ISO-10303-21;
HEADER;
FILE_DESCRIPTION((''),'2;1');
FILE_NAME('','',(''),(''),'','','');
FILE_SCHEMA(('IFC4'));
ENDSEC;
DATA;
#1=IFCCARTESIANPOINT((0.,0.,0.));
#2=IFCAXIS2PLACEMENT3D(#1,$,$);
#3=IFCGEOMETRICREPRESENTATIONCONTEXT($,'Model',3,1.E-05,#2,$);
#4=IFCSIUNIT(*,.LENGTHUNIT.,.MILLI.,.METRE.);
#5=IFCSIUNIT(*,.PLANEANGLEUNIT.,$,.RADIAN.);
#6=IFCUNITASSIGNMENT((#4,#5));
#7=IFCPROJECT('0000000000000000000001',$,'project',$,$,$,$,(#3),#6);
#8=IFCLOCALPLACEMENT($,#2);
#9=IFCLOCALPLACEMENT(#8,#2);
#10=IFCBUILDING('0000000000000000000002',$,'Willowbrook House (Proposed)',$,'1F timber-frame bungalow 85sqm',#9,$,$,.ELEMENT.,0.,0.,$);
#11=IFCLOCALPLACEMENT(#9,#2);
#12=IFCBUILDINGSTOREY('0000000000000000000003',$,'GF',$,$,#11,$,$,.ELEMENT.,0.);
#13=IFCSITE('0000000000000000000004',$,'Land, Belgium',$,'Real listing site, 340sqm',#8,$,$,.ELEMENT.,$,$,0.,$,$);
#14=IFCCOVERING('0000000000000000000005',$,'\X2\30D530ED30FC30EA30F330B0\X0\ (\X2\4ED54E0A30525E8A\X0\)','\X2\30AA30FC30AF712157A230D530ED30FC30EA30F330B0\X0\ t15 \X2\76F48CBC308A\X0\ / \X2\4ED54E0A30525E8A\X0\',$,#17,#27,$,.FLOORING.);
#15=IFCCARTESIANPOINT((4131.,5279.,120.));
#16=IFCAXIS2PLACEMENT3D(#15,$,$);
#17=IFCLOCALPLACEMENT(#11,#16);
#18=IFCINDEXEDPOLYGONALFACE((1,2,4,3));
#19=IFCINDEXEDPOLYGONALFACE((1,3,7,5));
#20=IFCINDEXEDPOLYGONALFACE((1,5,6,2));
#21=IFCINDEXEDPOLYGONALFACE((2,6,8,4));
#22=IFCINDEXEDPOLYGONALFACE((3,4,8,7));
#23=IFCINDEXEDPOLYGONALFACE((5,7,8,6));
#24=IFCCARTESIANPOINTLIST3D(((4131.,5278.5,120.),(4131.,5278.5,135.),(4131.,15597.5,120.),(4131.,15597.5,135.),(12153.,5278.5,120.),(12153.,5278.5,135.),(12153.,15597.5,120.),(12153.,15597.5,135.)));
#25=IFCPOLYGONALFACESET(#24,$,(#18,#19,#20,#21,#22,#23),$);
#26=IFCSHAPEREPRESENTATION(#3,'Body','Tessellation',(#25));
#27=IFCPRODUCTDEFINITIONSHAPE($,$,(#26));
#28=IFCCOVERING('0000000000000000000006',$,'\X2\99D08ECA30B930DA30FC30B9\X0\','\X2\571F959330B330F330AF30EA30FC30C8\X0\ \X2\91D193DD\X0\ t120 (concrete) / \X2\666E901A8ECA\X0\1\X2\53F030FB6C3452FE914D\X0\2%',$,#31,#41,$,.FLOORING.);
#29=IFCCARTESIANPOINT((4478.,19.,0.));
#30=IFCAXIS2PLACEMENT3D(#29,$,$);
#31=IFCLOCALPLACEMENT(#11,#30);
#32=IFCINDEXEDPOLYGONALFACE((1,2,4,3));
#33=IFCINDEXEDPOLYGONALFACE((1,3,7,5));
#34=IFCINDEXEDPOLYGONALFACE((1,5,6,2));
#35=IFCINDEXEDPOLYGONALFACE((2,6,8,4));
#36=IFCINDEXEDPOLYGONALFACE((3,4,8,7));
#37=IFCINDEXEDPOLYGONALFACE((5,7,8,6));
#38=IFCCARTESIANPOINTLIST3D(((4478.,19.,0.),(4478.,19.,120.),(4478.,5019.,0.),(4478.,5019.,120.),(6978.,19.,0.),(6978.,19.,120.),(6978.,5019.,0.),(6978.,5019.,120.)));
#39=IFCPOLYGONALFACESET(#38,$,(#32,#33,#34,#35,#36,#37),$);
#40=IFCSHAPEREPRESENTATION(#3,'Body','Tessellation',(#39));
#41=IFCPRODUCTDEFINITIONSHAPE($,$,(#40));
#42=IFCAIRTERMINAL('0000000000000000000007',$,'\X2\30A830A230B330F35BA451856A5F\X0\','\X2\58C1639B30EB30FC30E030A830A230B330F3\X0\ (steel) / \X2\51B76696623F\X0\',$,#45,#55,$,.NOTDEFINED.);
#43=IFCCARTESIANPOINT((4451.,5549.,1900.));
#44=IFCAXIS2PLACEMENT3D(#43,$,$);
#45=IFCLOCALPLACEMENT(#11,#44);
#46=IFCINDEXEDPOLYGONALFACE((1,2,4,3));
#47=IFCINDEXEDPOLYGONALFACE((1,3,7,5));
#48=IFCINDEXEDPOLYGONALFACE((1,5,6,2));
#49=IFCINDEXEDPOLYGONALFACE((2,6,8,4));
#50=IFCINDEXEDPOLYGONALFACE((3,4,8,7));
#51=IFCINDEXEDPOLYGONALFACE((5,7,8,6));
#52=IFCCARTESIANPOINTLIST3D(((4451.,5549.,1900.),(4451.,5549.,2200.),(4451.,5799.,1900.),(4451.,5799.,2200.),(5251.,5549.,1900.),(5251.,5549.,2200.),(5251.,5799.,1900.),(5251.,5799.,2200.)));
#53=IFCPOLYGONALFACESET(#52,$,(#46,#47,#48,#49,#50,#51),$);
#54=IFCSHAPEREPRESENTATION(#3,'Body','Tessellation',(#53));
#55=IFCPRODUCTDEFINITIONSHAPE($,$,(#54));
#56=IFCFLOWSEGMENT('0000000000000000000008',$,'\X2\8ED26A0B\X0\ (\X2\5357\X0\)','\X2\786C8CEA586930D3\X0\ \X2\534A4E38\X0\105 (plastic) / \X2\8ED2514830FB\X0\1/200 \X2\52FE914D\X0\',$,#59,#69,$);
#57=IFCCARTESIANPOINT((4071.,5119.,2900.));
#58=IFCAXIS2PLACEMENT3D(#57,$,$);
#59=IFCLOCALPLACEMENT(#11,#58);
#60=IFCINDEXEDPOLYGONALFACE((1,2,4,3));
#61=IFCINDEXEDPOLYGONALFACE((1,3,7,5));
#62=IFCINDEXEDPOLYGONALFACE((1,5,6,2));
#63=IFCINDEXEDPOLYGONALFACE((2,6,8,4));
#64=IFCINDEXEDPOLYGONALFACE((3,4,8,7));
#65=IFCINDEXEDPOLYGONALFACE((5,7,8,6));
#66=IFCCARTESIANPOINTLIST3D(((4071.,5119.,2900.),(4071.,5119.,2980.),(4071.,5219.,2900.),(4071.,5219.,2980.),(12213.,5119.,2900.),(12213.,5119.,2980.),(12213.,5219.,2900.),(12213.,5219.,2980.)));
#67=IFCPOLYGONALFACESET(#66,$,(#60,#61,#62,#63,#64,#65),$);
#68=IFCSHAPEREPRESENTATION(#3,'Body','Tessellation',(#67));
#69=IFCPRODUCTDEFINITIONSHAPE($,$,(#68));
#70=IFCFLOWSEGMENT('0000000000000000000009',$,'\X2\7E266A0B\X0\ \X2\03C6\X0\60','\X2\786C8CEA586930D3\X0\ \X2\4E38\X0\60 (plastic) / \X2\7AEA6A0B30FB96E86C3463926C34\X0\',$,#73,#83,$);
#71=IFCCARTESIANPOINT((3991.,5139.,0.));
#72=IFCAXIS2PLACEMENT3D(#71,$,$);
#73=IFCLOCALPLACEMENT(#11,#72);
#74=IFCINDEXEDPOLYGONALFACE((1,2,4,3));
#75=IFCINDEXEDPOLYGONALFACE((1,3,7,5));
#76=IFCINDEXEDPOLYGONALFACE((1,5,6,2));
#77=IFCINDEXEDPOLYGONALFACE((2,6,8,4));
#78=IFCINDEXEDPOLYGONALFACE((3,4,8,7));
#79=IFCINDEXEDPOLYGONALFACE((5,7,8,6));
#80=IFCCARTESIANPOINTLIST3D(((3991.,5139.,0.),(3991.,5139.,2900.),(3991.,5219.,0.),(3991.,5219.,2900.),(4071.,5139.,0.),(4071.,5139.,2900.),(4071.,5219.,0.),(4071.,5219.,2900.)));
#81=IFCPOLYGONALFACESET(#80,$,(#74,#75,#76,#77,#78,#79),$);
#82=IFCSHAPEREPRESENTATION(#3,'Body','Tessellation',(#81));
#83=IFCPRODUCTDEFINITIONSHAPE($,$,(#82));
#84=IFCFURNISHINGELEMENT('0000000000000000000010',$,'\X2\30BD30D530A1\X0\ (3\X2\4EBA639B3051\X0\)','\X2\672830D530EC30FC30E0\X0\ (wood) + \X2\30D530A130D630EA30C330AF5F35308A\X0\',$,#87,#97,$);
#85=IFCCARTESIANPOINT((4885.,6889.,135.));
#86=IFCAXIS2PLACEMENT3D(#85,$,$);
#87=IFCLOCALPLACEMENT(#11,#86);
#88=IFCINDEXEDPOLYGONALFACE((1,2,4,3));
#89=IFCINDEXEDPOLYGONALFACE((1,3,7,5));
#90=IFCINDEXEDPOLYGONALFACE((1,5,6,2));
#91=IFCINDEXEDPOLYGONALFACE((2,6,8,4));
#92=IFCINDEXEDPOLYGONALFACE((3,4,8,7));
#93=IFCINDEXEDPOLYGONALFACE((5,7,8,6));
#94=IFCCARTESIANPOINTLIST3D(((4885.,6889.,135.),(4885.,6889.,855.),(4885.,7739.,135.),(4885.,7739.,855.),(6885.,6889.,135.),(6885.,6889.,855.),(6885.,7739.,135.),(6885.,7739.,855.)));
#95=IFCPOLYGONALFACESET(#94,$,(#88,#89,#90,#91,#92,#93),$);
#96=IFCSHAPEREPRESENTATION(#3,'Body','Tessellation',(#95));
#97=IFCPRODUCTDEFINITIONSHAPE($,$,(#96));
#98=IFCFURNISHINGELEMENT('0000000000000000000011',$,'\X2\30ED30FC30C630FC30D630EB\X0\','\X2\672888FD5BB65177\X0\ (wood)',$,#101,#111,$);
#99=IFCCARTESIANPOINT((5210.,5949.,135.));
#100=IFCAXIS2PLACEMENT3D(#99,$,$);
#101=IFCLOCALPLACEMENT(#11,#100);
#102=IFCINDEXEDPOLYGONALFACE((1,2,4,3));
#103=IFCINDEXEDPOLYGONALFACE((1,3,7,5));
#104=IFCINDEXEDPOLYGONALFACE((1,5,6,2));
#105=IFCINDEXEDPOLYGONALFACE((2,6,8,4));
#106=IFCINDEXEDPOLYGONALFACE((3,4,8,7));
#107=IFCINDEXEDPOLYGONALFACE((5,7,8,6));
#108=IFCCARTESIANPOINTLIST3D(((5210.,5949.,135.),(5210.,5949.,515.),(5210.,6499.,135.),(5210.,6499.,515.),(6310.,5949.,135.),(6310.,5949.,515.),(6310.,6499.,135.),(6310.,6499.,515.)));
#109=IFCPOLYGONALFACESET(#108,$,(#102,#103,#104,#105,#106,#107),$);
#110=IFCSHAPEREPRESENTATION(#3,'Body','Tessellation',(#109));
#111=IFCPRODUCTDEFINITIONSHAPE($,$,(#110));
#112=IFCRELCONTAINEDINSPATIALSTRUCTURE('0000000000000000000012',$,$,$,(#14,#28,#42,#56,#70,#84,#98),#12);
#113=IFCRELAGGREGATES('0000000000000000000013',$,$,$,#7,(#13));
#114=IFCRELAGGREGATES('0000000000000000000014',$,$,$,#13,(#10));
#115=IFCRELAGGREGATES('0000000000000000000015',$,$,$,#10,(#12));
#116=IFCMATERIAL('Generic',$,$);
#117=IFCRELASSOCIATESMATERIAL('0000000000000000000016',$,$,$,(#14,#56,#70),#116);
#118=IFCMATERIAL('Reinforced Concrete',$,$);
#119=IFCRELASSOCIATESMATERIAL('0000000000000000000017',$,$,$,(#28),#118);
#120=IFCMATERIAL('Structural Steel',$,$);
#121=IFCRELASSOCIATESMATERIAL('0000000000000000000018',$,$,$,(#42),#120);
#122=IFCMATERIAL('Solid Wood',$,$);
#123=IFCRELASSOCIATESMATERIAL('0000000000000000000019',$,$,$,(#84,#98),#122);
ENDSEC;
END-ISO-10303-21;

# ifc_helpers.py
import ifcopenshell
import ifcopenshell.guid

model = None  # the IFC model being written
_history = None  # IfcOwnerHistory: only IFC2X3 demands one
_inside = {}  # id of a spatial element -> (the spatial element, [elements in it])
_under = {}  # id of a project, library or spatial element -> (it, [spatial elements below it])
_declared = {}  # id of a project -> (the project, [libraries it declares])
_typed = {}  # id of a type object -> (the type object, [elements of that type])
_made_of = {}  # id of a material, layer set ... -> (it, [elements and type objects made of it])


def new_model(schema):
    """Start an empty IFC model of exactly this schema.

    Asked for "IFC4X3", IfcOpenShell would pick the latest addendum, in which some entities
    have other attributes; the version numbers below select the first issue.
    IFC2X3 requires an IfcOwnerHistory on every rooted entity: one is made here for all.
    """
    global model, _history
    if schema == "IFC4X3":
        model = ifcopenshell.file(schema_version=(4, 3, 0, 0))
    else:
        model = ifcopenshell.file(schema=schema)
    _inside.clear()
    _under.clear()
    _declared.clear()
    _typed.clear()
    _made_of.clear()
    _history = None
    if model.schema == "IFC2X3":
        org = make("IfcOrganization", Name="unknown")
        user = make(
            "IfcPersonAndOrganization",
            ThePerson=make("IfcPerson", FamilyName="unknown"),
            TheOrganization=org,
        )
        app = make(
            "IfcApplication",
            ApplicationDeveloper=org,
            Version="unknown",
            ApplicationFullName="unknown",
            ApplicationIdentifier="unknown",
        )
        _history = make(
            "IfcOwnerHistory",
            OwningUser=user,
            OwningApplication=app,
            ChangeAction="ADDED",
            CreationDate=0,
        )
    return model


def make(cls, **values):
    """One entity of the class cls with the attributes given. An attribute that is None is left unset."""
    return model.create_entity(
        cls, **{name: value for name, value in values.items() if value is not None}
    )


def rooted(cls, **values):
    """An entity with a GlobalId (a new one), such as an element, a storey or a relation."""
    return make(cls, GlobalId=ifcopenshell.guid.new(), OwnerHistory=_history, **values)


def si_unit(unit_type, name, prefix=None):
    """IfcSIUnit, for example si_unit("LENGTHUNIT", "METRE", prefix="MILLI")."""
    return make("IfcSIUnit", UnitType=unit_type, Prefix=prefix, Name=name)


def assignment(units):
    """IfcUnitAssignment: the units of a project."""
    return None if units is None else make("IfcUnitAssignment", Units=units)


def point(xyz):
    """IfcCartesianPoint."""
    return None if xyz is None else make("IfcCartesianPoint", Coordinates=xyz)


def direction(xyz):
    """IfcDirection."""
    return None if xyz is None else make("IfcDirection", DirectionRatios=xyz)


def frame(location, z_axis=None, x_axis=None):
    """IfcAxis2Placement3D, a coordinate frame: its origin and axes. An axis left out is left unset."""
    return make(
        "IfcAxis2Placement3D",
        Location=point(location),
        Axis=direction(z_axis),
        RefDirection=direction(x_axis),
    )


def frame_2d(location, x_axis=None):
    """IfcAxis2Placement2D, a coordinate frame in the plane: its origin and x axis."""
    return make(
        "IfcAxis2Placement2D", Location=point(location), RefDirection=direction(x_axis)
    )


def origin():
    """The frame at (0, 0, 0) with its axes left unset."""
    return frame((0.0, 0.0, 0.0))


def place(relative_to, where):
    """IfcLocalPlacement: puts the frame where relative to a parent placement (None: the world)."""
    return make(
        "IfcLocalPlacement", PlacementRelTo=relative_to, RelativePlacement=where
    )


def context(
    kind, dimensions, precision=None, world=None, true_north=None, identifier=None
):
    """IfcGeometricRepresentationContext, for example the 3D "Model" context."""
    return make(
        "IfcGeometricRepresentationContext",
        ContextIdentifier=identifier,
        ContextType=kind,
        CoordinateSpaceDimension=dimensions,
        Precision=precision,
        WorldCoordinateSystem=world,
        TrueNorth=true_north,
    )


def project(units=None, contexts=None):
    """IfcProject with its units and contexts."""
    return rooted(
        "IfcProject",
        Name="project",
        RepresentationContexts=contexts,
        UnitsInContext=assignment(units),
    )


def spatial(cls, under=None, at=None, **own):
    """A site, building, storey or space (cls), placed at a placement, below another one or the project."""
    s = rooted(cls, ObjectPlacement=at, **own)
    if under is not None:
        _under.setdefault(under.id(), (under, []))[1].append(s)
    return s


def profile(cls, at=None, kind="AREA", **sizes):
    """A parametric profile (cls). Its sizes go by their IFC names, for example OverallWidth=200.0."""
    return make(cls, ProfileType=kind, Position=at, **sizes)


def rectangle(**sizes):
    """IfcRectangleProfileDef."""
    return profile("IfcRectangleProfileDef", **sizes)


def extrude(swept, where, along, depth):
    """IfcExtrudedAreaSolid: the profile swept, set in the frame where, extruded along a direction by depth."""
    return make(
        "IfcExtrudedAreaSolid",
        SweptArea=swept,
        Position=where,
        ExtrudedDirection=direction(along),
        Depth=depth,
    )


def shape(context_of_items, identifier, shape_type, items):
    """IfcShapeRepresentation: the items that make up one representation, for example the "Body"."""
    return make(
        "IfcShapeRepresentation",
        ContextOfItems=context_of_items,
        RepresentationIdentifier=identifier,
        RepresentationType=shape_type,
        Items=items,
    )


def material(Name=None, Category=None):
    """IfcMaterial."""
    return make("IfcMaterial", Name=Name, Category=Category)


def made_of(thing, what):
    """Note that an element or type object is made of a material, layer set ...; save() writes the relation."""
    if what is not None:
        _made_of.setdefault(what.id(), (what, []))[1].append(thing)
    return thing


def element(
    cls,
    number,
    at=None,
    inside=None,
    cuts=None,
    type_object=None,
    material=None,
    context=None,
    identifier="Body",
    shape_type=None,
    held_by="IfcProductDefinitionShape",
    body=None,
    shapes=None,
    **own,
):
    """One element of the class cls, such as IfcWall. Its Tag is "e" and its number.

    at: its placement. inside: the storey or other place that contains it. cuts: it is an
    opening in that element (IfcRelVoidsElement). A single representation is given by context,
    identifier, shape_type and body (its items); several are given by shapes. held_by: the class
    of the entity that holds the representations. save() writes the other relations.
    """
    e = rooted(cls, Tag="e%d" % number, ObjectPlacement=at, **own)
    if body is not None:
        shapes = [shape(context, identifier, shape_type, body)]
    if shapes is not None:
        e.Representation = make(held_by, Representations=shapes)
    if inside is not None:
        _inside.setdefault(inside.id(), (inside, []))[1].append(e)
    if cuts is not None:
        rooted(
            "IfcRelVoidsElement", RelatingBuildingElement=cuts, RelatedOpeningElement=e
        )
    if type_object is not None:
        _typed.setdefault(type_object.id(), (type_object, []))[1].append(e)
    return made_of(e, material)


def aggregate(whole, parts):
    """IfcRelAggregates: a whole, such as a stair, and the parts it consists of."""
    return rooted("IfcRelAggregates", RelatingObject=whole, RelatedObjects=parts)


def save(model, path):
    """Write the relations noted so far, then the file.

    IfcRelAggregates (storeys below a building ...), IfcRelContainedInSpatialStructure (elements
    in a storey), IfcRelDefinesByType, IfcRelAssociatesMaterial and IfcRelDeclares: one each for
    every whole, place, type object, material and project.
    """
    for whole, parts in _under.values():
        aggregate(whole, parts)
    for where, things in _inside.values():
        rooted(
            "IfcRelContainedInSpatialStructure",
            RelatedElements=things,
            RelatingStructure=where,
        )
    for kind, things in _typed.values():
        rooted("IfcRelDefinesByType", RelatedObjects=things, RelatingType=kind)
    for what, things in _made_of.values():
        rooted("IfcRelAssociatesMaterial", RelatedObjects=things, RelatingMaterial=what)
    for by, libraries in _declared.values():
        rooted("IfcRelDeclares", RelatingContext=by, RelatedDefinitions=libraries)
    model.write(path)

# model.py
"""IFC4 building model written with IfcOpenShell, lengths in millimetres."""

from ifc_helpers import new_model, si_unit, frame, frame_2d, origin, place, context, project, spatial, rectangle, extrude, material, element, save


model = new_model("IFC4")

# Units and contexts
model_context = context("Model", 3, precision=1e-05, world=origin())
ifc_project = project(units=[si_unit("LENGTHUNIT", "METRE", prefix="MILLI"), si_unit("PLANEANGLEUNIT", "RADIAN")], contexts=[model_context])

# Site, building, storey
site_placement = place(None, origin())
site = spatial("IfcSite", under=ifc_project, at=site_placement, Name="Land, Belgium", ObjectType="Real listing site, 340sqm", CompositionType="ELEMENT", RefElevation=0.0)
building_placement = place(site_placement, origin())
building = spatial("IfcBuilding", under=site, at=building_placement, Name="Willowbrook House (Proposed)", ObjectType="1F timber-frame bungalow 85sqm", CompositionType="ELEMENT", ElevationOfRefHeight=0.0, ElevationOfTerrain=0.0)
storey_placement = place(building_placement, origin())
storey = spatial("IfcBuildingStorey", under=building, at=storey_placement, Name="GF", CompositionType="ELEMENT", Elevation=0.0)

# Shared definitions
ifc_material_1 = material(Name="Solid Wood")

# Shared definitions
ifc_material_2 = material(Name="Reinforced Concrete")

# Shared definitions
ifc_material_3 = material(Name="Structural Steel")

# Coverings
ifc_material_4 = material(Name="Generic")
covering_1_placement = place(storey_placement, frame((4131.0, 5279.0, 120.0)))
element("IfcCovering", 1, at=covering_1_placement, inside=storey, material=ifc_material_4, Name="フローリング (仕上げ床)", Description="オーク無垢フローリング t15 直貼り / 仕上げ床", PredefinedType="FLOORING", context=model_context, shape_type="SweptSolid", body=[
    extrude(rectangle(XDim=8022.0, YDim=10319.0, at=frame_2d((4011.0, 5159.0))), frame((4131.0, 5279.0, 120.0)), (0.0, 0.0, 1.0), 15.0),
])
covering_2_placement = place(storey_placement, frame((4478.0, 19.0, 0.0)))
element("IfcCovering", 2, at=covering_2_placement, inside=storey, material=ifc_material_2, Name="駐車スペース", Description="土間コンクリート 金鏝 t120 (concrete) / 普通車1台・水勾配2%", PredefinedType="FLOORING", context=model_context, shape_type="SweptSolid", body=[
    extrude(rectangle(XDim=2500.0, YDim=5000.0, at=frame_2d((1250.0, 2500.0))), frame((4478.0, 19.0, 0.0)), (0.0, 0.0, 1.0), 120.0),
])

# Air terminal
air_terminal_placement = place(storey_placement, frame((4451.0, 5549.0, 1900.0)))
element("IfcAirTerminal", 3, at=air_terminal_placement, inside=storey, material=ifc_material_3, Name="エアコン室内機", Description="壁掛ルームエアコン (steel) / 冷暖房", PredefinedType="NOTDEFINED", context=model_context, shape_type="SweptSolid", body=[
    extrude(rectangle(XDim=800.0, YDim=250.0, at=frame_2d((400.0, 125.0))), frame((4451.0, 5549.0, 1900.0)), (0.0, 0.0, 1.0), 300.0),
])

# Flow segments
flow_segment_1_placement = place(storey_placement, frame((4071.0, 5119.0, 2900.0)))
element("IfcFlowSegment", 4, at=flow_segment_1_placement, inside=storey, material=ifc_material_4, Name="軒樋 (南)", Description="硬質塩ビ 半丸105 (plastic) / 軒先・1/200 勾配", context=model_context, shape_type="SweptSolid", body=[
    extrude(rectangle(XDim=8142.0, YDim=100.0, at=frame_2d((4071.0, 50.0))), frame((4071.0, 5119.0, 2900.0)), (0.0, 0.0, 1.0), 80.0),
])
flow_segment_2_placement = place(storey_placement, frame((3991.0, 5139.0, 0.0)))
element("IfcFlowSegment", 5, at=flow_segment_2_placement, inside=storey, material=ifc_material_4, Name="縦樋 φ60", Description="硬質塩ビ 丸60 (plastic) / 竪樋・雨水排水", context=model_context, shape_type="SweptSolid", body=[
    extrude(rectangle(XDim=80.0, YDim=80.0, at=frame_2d((40.0, 40.0))), frame((3991.0, 5139.0, 0.0)), (0.0, 0.0, 1.0), 2900.0),
])

# Furnishing elements
furnishing_1_placement = place(storey_placement, frame((4885.0, 6889.0, 135.0)))
element("IfcFurnishingElement", 6, at=furnishing_1_placement, inside=storey, material=ifc_material_1, Name="ソファ (3人掛け)", Description="木フレーム (wood) + ファブリック張り", context=model_context, shape_type="SweptSolid", body=[
    extrude(rectangle(XDim=2000.0, YDim=850.0, at=frame_2d((1000.0, 425.0))), frame((4885.0, 6889.0, 135.0)), (0.0, 0.0, 1.0), 720.0),
])
furnishing_2_placement = place(storey_placement, frame((5210.0, 5949.0, 135.0)))
element("IfcFurnishingElement", 7, at=furnishing_2_placement, inside=storey, material=ifc_material_1, Name="ローテーブル", Description="木製家具 (wood)", context=model_context, shape_type="SweptSolid", body=[
    extrude(rectangle(XDim=1100.0, YDim=550.0, at=frame_2d((550.0, 275.0))), frame((5210.0, 5949.0, 135.0)), (0.0, 0.0, 1.0), 380.0),
])

save(model, "model.ifc")
